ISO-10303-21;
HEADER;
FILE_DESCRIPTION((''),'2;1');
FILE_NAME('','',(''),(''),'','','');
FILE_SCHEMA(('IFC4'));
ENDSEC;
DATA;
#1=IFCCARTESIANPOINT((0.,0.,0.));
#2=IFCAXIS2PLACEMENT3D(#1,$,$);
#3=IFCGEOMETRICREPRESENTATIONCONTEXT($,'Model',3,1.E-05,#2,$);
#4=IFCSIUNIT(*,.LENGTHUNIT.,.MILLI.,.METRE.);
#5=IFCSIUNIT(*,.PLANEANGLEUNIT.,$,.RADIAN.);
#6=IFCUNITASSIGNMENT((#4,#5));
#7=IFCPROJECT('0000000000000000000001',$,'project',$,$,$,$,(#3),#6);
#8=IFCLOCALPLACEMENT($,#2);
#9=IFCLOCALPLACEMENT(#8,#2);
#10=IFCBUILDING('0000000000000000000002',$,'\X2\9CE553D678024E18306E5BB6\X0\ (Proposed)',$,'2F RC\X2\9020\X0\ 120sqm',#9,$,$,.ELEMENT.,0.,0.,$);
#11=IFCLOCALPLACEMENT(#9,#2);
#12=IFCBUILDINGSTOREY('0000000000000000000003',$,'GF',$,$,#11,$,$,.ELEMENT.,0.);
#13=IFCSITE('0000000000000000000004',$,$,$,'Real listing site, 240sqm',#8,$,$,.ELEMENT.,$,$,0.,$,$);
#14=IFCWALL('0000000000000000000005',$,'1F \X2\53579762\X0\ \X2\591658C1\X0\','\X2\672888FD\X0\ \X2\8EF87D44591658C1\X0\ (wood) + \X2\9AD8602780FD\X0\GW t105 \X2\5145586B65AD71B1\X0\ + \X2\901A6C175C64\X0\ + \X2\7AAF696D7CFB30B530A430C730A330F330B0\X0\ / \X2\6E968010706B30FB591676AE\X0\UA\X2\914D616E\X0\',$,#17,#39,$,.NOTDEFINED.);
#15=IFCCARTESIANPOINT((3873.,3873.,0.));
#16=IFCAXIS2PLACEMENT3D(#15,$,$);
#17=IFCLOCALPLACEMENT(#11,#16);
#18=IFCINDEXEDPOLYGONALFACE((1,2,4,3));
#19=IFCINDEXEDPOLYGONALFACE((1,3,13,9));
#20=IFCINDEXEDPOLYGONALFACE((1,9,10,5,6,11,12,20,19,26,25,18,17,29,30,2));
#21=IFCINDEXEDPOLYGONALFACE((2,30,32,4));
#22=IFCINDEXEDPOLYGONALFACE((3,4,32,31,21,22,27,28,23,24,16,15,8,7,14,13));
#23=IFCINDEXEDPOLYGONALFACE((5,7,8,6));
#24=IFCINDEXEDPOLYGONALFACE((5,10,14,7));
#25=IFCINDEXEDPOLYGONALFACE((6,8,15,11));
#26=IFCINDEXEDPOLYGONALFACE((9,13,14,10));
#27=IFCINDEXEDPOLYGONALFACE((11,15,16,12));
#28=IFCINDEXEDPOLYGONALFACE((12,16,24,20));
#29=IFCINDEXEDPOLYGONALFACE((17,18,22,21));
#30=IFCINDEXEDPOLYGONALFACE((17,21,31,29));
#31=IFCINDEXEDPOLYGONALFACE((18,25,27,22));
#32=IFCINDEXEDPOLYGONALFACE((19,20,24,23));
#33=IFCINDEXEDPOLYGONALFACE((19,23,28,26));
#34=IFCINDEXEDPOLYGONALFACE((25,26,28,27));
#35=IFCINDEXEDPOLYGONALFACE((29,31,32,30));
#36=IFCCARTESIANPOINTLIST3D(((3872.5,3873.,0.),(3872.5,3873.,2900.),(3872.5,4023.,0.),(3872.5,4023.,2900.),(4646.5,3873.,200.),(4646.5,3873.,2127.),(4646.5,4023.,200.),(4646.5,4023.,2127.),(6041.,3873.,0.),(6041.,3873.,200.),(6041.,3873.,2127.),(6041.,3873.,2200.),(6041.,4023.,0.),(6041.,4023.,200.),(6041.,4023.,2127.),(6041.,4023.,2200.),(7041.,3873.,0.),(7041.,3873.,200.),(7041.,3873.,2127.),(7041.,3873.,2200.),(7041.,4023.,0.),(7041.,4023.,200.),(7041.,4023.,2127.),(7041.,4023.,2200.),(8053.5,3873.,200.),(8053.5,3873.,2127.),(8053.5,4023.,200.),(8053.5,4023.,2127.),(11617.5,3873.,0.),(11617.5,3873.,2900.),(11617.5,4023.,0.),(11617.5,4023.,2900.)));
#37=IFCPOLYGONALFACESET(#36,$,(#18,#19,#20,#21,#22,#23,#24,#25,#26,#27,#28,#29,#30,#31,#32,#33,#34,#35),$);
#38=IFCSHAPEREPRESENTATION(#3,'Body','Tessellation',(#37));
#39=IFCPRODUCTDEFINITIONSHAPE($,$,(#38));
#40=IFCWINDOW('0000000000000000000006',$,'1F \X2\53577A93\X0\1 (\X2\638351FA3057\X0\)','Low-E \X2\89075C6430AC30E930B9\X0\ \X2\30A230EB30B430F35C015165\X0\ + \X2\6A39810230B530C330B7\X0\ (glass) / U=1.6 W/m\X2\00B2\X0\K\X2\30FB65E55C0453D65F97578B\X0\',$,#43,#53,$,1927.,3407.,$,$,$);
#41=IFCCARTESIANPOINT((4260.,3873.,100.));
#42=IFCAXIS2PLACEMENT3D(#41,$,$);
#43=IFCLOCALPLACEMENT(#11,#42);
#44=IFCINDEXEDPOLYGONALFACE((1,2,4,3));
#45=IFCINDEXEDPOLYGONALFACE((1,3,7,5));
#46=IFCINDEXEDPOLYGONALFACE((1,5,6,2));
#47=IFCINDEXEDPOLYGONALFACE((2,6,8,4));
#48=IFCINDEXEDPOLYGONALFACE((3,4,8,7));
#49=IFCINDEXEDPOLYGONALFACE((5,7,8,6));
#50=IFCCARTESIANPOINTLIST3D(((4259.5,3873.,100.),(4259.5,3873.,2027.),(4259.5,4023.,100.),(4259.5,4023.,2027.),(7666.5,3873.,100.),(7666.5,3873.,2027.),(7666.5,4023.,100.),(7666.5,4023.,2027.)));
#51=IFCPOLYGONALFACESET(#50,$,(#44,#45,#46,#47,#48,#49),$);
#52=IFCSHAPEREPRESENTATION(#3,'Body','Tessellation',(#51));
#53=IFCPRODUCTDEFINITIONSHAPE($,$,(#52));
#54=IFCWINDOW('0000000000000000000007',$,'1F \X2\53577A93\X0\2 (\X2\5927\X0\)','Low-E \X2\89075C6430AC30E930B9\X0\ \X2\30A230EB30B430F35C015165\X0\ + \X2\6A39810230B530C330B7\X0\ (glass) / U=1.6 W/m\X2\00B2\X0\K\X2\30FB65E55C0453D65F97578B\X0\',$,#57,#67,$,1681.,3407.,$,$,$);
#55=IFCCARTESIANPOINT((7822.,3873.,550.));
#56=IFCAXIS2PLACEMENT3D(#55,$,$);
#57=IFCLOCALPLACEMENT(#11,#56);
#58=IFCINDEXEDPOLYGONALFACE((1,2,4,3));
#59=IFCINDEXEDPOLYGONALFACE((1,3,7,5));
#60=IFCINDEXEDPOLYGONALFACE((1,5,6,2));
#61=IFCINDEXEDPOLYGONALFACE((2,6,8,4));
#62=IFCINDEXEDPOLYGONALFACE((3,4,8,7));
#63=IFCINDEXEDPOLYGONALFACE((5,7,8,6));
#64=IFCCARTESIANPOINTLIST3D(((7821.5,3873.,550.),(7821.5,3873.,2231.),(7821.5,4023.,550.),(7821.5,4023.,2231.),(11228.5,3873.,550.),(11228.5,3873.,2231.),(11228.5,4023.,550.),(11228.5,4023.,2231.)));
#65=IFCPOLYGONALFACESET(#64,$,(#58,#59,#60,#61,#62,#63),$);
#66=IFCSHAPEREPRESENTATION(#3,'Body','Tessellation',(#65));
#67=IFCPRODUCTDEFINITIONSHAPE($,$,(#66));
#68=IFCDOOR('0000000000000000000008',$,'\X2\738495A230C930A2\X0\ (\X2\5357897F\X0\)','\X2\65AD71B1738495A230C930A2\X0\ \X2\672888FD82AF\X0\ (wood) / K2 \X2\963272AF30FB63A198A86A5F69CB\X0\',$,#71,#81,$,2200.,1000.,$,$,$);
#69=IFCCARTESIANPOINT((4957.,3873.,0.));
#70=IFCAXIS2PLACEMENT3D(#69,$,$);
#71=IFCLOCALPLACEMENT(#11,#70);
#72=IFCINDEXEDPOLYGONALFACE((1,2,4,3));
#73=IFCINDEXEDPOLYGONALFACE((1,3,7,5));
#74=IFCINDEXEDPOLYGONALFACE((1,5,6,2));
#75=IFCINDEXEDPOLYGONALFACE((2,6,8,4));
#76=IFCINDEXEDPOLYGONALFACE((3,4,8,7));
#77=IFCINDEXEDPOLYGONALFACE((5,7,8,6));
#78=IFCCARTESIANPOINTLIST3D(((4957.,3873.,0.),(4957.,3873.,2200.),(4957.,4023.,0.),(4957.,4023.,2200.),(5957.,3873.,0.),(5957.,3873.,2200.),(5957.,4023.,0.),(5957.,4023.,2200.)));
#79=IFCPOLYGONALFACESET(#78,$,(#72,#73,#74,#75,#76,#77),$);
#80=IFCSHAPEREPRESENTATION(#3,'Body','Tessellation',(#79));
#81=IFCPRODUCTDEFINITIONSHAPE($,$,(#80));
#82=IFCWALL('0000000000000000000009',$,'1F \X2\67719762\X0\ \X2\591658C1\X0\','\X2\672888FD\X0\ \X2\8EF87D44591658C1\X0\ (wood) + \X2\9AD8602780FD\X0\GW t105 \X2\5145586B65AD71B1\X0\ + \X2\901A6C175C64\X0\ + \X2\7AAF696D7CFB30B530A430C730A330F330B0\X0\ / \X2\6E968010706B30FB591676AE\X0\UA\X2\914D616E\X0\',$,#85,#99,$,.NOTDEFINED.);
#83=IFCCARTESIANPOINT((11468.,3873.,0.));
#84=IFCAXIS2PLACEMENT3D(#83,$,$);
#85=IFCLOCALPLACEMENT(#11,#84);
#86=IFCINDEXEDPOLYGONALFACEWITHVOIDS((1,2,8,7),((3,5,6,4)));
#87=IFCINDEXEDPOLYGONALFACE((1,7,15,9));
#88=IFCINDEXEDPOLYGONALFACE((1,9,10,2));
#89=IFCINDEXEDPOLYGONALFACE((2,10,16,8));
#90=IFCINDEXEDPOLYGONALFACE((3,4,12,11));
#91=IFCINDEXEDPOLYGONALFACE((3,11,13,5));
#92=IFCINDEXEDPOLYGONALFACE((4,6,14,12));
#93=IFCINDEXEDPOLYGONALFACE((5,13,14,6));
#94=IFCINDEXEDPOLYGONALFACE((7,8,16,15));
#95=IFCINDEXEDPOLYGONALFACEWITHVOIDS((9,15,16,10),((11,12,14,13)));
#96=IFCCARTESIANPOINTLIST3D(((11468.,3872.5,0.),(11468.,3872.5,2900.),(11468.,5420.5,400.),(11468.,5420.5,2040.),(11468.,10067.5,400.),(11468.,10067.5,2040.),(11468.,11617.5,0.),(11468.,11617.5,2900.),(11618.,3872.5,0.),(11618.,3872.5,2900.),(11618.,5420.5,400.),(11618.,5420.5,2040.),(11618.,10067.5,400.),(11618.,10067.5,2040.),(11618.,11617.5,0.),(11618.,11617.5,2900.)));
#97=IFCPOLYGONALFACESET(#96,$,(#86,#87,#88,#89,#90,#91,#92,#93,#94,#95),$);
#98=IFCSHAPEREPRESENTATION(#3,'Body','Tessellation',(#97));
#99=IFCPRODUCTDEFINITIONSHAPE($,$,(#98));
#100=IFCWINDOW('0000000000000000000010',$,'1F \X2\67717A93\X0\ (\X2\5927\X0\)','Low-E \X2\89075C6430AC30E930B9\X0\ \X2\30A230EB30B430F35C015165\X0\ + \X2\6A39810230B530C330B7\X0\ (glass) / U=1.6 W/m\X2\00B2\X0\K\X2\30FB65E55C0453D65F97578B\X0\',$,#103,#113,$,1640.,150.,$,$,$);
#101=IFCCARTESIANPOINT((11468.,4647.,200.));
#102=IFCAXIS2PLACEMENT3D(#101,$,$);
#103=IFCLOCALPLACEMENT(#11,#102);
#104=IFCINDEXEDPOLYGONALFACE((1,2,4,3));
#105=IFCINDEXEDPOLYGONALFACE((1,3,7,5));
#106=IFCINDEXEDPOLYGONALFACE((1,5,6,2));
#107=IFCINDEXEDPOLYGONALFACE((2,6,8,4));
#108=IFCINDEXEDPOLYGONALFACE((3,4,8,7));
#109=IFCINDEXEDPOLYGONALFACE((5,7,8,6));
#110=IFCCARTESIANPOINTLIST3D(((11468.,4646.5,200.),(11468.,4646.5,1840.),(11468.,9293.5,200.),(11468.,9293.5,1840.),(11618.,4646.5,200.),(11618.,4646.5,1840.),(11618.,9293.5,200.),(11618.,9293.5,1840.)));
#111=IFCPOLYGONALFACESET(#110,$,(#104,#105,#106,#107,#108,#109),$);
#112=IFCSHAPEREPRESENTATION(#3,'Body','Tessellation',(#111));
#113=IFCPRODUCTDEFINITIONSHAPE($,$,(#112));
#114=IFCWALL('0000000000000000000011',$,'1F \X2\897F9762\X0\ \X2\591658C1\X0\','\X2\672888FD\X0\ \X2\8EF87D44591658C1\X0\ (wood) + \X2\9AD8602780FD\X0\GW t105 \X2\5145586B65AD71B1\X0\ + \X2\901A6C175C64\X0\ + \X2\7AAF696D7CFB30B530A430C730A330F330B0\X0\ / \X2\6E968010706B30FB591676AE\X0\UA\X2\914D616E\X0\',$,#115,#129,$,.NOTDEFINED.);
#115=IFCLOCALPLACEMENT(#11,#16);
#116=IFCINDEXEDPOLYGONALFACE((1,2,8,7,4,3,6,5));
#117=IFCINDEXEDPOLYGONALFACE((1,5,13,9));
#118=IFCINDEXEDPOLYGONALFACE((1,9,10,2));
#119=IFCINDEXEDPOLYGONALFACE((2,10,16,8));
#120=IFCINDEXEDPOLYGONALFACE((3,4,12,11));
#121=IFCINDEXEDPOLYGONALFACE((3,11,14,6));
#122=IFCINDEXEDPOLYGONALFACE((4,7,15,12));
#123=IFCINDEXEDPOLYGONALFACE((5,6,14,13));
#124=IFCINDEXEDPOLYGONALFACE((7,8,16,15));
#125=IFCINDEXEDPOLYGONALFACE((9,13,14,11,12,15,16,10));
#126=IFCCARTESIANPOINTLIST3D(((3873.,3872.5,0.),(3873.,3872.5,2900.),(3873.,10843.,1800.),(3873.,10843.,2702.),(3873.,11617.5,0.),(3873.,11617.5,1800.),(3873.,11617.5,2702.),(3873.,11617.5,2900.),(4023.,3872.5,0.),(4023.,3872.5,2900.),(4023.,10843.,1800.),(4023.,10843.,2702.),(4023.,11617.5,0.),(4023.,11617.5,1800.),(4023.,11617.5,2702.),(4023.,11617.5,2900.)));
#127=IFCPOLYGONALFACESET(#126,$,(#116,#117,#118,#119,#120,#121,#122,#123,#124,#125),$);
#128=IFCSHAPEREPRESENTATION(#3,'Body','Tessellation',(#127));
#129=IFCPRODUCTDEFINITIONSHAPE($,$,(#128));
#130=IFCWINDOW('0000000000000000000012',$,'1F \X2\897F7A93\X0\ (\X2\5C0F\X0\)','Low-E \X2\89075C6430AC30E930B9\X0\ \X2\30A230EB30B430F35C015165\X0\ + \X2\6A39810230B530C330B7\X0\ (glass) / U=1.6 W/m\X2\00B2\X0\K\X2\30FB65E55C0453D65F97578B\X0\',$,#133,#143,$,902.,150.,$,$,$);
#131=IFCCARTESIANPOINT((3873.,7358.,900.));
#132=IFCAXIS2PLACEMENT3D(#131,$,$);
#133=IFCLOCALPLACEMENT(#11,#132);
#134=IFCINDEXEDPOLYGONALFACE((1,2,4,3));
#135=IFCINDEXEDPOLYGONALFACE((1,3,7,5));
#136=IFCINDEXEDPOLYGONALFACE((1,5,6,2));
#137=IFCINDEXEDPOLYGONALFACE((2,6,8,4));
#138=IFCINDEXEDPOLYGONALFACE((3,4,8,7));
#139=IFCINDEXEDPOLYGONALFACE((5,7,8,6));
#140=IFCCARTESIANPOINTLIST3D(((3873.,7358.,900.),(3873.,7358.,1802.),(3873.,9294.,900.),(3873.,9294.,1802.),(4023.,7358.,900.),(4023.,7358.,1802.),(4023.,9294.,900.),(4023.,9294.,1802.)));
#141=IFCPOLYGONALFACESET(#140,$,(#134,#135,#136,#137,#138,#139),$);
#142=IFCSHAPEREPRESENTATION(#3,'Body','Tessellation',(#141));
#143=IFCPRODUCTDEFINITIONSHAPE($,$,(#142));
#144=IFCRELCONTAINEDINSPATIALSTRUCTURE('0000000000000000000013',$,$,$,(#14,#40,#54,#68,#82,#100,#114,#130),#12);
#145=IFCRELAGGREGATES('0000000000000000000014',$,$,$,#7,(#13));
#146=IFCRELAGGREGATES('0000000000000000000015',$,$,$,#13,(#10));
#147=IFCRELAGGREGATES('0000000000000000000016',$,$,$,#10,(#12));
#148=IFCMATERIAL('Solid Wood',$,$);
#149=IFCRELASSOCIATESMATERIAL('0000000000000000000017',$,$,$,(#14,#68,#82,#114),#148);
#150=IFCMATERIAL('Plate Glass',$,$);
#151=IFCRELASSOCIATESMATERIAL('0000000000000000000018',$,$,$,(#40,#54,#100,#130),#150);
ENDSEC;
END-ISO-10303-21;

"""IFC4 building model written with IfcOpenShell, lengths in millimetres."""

from ifc_helpers import new_model, si_unit, frame, frame_2d, origin, place, context, project, spatial, rectangle, extrude, material, element, fill, save


model = new_model("IFC4")

# Units and contexts
model_context = context("Model", 3, precision=1e-05, world=origin())
ifc_project = project(units=[si_unit("LENGTHUNIT", "METRE", prefix="MILLI"), si_unit("PLANEANGLEUNIT", "RADIAN")], contexts=[model_context])

# Site, building, storey
site_placement = place(None, origin())
site = spatial("IfcSite", under=ifc_project, at=site_placement, ObjectType="Real listing site, 240sqm", CompositionType="ELEMENT", RefElevation=0.0)
building_placement = place(site_placement, origin())
building = spatial("IfcBuilding", under=site, at=building_placement, Name="鳥取砂丘の家 (Proposed)", ObjectType="2F RC造 120sqm", CompositionType="ELEMENT", ElevationOfRefHeight=0.0, ElevationOfTerrain=0.0)
storey_placement = place(building_placement, origin())
storey = spatial("IfcBuildingStorey", under=building, at=storey_placement, Name="GF", CompositionType="ELEMENT", Elevation=0.0)

# Shared definitions
ifc_material_1 = material(Name="Solid Wood")

# Wall, openings, windows, door
wall_1_placement = place(storey_placement, frame((3873.0, 3873.0, 0.0)))
wall_1 = element("IfcWall", 1, at=wall_1_placement, inside=storey, material=ifc_material_1, Name="1F 南面 外壁", Description="木製 軸組外壁 (wood) + 高性能GW t105 充填断熱 + 通気層 + 窯業系サイディング / 準耐火・外皮UA配慮", PredefinedType="NOTDEFINED", context=model_context, shape_type="SweptSolid", body=[
    extrude(rectangle(XDim=7745.0, YDim=150.0, at=frame_2d((3872.0, 75.0))), frame((3873.0, 3873.0, 0.0)), (0.0, 0.0, 1.0), 2900.0),
])
opening_1_placement = place(storey_placement, frame((4260.0, 3873.0, 100.0)))
opening_1 = element("IfcOpeningElement", 2, at=opening_1_placement, cuts=wall_1, PredefinedType="NOTDEFINED", context=model_context, shape_type="SweptSolid", body=[
    extrude(rectangle(XDim=3407.0, YDim=150.0, at=frame_2d((1703.0, 75.0))), frame((4260.0, 3873.0, 100.0)), (0.0, 0.0, 1.0), 1927.0),
])
opening_2_placement = place(storey_placement, frame((7822.0, 3873.0, 550.0)))
opening_2 = element("IfcOpeningElement", 3, at=opening_2_placement, cuts=wall_1, PredefinedType="NOTDEFINED", context=model_context, shape_type="SweptSolid", body=[
    extrude(rectangle(XDim=3407.0, YDim=150.0, at=frame_2d((1703.0, 75.0))), frame((7822.0, 3873.0, 550.0)), (0.0, 0.0, 1.0), 1681.0),
])
opening_3_placement = place(storey_placement, frame((4957.0, 3873.0, 0.0)))
opening_3 = element("IfcOpeningElement", 4, at=opening_3_placement, cuts=wall_1, PredefinedType="NOTDEFINED", context=model_context, shape_type="SweptSolid", body=[
    extrude(rectangle(XDim=1000.0, YDim=150.0, at=frame_2d((500.0, 75.0))), frame((4957.0, 3873.0, 0.0)), (0.0, 0.0, 1.0), 2200.0),
])
ifc_material_2 = material(Name="Plate Glass")
window_1_placement = place(storey_placement, frame((4260.0, 3873.0, 100.0)))
window_1 = element("IfcWindow", 5, at=window_1_placement, inside=storey, material=ifc_material_2, Name="1F 南窓1 (掃出し)", Description="Low-E 複層ガラス アルゴン封入 + 樹脂サッシ (glass) / U=1.6 W/m²K・日射取得型", OverallHeight=1927.0, OverallWidth=3407.0, context=model_context, shape_type="SweptSolid", body=[
    extrude(rectangle(XDim=3407.0, YDim=150.0, at=frame_2d((1703.0, 75.0))), frame((4260.0, 3873.0, 100.0)), (0.0, 0.0, 1.0), 1927.0),
])
fill(opening_1, window_1)
window_2_placement = place(storey_placement, frame((7822.0, 3873.0, 550.0)))
window_2 = element("IfcWindow", 6, at=window_2_placement, inside=storey, material=ifc_material_2, Name="1F 南窓2 (大)", Description="Low-E 複層ガラス アルゴン封入 + 樹脂サッシ (glass) / U=1.6 W/m²K・日射取得型", OverallHeight=1681.0, OverallWidth=3407.0, context=model_context, shape_type="SweptSolid", body=[
    extrude(rectangle(XDim=3407.0, YDim=150.0, at=frame_2d((1703.0, 75.0))), frame((7822.0, 3873.0, 550.0)), (0.0, 0.0, 1.0), 1681.0),
])
fill(opening_2, window_2)
door_placement = place(storey_placement, frame((4957.0, 3873.0, 0.0)))
door = element("IfcDoor", 7, at=door_placement, inside=storey, material=ifc_material_1, Name="玄関ドア (南西)", Description="断熱玄関ドア 木製芯 (wood) / K2 防犯・採風機構", OverallHeight=2200.0, OverallWidth=1000.0, context=model_context, shape_type="SweptSolid", body=[
    extrude(rectangle(XDim=1000.0, YDim=150.0, at=frame_2d((500.0, 75.0))), frame((4957.0, 3873.0, 0.0)), (0.0, 0.0, 1.0), 2200.0),
])
fill(opening_3, door)

# Walls, openings, windows
wall_2_placement = place(storey_placement, frame((11468.0, 3873.0, 0.0)))
wall_2 = element("IfcWall", 8, at=wall_2_placement, inside=storey, material=ifc_material_1, Name="1F 東面 外壁", Description="木製 軸組外壁 (wood) + 高性能GW t105 充填断熱 + 通気層 + 窯業系サイディング / 準耐火・外皮UA配慮", PredefinedType="NOTDEFINED", context=model_context, shape_type="SweptSolid", body=[
    extrude(rectangle(XDim=150.0, YDim=7745.0, at=frame_2d((75.0, 3872.0))), frame((11468.0, 3873.0, 0.0)), (0.0, 0.0, 1.0), 2900.0),
])
opening_4_placement = place(storey_placement, frame((11468.0, 4647.0, 200.0)))
opening_4 = element("IfcOpeningElement", 9, at=opening_4_placement, cuts=wall_2, PredefinedType="NOTDEFINED", context=model_context, shape_type="SweptSolid", body=[
    extrude(rectangle(XDim=150.0, YDim=4647.0, at=frame_2d((75.0, 2323.0))), frame((11468.0, 4647.0, 200.0)), (0.0, 0.0, 1.0), 1640.0),
])
window_3_placement = place(storey_placement, frame((11468.0, 4647.0, 200.0)))
window_3 = element("IfcWindow", 10, at=window_3_placement, inside=storey, material=ifc_material_2, Name="1F 東窓 (大)", Description="Low-E 複層ガラス アルゴン封入 + 樹脂サッシ (glass) / U=1.6 W/m²K・日射取得型", OverallHeight=1640.0, OverallWidth=150.0, context=model_context, shape_type="SweptSolid", body=[
    extrude(rectangle(XDim=150.0, YDim=4647.0, at=frame_2d((75.0, 2323.0))), frame((11468.0, 4647.0, 200.0)), (0.0, 0.0, 1.0), 1640.0),
])
fill(opening_4, window_3)
wall_3_placement = place(storey_placement, frame((3873.0, 3873.0, 0.0)))
wall_3 = element("IfcWall", 11, at=wall_3_placement, inside=storey, material=ifc_material_1, Name="1F 西面 外壁", Description="木製 軸組外壁 (wood) + 高性能GW t105 充填断熱 + 通気層 + 窯業系サイディング / 準耐火・外皮UA配慮", PredefinedType="NOTDEFINED", context=model_context, shape_type="SweptSolid", body=[
    extrude(rectangle(XDim=150.0, YDim=7745.0, at=frame_2d((75.0, 3872.0))), frame((3873.0, 3873.0, 0.0)), (0.0, 0.0, 1.0), 2900.0),
])
opening_5_placement = place(storey_placement, frame((3873.0, 7358.0, 900.0)))
opening_5 = element("IfcOpeningElement", 12, at=opening_5_placement, cuts=wall_3, PredefinedType="NOTDEFINED", context=model_context, shape_type="SweptSolid", body=[
    extrude(rectangle(XDim=150.0, YDim=1936.0, at=frame_2d((75.0, 968.0))), frame((3873.0, 7358.0, 900.0)), (0.0, 0.0, 1.0), 902.0),
])
window_4_placement = place(storey_placement, frame((3873.0, 7358.0, 900.0)))
window_4 = element("IfcWindow", 13, at=window_4_placement, inside=storey, material=ifc_material_2, Name="1F 西窓 (小)", Description="Low-E 複層ガラス アルゴン封入 + 樹脂サッシ (glass) / U=1.6 W/m²K・日射取得型", OverallHeight=902.0, OverallWidth=150.0, context=model_context, shape_type="SweptSolid", body=[
    extrude(rectangle(XDim=150.0, YDim=1936.0, at=frame_2d((75.0, 968.0))), frame((3873.0, 7358.0, 900.0)), (0.0, 0.0, 1.0), 902.0),
])
fill(opening_5, window_4)

save(model, "model.ifc")
